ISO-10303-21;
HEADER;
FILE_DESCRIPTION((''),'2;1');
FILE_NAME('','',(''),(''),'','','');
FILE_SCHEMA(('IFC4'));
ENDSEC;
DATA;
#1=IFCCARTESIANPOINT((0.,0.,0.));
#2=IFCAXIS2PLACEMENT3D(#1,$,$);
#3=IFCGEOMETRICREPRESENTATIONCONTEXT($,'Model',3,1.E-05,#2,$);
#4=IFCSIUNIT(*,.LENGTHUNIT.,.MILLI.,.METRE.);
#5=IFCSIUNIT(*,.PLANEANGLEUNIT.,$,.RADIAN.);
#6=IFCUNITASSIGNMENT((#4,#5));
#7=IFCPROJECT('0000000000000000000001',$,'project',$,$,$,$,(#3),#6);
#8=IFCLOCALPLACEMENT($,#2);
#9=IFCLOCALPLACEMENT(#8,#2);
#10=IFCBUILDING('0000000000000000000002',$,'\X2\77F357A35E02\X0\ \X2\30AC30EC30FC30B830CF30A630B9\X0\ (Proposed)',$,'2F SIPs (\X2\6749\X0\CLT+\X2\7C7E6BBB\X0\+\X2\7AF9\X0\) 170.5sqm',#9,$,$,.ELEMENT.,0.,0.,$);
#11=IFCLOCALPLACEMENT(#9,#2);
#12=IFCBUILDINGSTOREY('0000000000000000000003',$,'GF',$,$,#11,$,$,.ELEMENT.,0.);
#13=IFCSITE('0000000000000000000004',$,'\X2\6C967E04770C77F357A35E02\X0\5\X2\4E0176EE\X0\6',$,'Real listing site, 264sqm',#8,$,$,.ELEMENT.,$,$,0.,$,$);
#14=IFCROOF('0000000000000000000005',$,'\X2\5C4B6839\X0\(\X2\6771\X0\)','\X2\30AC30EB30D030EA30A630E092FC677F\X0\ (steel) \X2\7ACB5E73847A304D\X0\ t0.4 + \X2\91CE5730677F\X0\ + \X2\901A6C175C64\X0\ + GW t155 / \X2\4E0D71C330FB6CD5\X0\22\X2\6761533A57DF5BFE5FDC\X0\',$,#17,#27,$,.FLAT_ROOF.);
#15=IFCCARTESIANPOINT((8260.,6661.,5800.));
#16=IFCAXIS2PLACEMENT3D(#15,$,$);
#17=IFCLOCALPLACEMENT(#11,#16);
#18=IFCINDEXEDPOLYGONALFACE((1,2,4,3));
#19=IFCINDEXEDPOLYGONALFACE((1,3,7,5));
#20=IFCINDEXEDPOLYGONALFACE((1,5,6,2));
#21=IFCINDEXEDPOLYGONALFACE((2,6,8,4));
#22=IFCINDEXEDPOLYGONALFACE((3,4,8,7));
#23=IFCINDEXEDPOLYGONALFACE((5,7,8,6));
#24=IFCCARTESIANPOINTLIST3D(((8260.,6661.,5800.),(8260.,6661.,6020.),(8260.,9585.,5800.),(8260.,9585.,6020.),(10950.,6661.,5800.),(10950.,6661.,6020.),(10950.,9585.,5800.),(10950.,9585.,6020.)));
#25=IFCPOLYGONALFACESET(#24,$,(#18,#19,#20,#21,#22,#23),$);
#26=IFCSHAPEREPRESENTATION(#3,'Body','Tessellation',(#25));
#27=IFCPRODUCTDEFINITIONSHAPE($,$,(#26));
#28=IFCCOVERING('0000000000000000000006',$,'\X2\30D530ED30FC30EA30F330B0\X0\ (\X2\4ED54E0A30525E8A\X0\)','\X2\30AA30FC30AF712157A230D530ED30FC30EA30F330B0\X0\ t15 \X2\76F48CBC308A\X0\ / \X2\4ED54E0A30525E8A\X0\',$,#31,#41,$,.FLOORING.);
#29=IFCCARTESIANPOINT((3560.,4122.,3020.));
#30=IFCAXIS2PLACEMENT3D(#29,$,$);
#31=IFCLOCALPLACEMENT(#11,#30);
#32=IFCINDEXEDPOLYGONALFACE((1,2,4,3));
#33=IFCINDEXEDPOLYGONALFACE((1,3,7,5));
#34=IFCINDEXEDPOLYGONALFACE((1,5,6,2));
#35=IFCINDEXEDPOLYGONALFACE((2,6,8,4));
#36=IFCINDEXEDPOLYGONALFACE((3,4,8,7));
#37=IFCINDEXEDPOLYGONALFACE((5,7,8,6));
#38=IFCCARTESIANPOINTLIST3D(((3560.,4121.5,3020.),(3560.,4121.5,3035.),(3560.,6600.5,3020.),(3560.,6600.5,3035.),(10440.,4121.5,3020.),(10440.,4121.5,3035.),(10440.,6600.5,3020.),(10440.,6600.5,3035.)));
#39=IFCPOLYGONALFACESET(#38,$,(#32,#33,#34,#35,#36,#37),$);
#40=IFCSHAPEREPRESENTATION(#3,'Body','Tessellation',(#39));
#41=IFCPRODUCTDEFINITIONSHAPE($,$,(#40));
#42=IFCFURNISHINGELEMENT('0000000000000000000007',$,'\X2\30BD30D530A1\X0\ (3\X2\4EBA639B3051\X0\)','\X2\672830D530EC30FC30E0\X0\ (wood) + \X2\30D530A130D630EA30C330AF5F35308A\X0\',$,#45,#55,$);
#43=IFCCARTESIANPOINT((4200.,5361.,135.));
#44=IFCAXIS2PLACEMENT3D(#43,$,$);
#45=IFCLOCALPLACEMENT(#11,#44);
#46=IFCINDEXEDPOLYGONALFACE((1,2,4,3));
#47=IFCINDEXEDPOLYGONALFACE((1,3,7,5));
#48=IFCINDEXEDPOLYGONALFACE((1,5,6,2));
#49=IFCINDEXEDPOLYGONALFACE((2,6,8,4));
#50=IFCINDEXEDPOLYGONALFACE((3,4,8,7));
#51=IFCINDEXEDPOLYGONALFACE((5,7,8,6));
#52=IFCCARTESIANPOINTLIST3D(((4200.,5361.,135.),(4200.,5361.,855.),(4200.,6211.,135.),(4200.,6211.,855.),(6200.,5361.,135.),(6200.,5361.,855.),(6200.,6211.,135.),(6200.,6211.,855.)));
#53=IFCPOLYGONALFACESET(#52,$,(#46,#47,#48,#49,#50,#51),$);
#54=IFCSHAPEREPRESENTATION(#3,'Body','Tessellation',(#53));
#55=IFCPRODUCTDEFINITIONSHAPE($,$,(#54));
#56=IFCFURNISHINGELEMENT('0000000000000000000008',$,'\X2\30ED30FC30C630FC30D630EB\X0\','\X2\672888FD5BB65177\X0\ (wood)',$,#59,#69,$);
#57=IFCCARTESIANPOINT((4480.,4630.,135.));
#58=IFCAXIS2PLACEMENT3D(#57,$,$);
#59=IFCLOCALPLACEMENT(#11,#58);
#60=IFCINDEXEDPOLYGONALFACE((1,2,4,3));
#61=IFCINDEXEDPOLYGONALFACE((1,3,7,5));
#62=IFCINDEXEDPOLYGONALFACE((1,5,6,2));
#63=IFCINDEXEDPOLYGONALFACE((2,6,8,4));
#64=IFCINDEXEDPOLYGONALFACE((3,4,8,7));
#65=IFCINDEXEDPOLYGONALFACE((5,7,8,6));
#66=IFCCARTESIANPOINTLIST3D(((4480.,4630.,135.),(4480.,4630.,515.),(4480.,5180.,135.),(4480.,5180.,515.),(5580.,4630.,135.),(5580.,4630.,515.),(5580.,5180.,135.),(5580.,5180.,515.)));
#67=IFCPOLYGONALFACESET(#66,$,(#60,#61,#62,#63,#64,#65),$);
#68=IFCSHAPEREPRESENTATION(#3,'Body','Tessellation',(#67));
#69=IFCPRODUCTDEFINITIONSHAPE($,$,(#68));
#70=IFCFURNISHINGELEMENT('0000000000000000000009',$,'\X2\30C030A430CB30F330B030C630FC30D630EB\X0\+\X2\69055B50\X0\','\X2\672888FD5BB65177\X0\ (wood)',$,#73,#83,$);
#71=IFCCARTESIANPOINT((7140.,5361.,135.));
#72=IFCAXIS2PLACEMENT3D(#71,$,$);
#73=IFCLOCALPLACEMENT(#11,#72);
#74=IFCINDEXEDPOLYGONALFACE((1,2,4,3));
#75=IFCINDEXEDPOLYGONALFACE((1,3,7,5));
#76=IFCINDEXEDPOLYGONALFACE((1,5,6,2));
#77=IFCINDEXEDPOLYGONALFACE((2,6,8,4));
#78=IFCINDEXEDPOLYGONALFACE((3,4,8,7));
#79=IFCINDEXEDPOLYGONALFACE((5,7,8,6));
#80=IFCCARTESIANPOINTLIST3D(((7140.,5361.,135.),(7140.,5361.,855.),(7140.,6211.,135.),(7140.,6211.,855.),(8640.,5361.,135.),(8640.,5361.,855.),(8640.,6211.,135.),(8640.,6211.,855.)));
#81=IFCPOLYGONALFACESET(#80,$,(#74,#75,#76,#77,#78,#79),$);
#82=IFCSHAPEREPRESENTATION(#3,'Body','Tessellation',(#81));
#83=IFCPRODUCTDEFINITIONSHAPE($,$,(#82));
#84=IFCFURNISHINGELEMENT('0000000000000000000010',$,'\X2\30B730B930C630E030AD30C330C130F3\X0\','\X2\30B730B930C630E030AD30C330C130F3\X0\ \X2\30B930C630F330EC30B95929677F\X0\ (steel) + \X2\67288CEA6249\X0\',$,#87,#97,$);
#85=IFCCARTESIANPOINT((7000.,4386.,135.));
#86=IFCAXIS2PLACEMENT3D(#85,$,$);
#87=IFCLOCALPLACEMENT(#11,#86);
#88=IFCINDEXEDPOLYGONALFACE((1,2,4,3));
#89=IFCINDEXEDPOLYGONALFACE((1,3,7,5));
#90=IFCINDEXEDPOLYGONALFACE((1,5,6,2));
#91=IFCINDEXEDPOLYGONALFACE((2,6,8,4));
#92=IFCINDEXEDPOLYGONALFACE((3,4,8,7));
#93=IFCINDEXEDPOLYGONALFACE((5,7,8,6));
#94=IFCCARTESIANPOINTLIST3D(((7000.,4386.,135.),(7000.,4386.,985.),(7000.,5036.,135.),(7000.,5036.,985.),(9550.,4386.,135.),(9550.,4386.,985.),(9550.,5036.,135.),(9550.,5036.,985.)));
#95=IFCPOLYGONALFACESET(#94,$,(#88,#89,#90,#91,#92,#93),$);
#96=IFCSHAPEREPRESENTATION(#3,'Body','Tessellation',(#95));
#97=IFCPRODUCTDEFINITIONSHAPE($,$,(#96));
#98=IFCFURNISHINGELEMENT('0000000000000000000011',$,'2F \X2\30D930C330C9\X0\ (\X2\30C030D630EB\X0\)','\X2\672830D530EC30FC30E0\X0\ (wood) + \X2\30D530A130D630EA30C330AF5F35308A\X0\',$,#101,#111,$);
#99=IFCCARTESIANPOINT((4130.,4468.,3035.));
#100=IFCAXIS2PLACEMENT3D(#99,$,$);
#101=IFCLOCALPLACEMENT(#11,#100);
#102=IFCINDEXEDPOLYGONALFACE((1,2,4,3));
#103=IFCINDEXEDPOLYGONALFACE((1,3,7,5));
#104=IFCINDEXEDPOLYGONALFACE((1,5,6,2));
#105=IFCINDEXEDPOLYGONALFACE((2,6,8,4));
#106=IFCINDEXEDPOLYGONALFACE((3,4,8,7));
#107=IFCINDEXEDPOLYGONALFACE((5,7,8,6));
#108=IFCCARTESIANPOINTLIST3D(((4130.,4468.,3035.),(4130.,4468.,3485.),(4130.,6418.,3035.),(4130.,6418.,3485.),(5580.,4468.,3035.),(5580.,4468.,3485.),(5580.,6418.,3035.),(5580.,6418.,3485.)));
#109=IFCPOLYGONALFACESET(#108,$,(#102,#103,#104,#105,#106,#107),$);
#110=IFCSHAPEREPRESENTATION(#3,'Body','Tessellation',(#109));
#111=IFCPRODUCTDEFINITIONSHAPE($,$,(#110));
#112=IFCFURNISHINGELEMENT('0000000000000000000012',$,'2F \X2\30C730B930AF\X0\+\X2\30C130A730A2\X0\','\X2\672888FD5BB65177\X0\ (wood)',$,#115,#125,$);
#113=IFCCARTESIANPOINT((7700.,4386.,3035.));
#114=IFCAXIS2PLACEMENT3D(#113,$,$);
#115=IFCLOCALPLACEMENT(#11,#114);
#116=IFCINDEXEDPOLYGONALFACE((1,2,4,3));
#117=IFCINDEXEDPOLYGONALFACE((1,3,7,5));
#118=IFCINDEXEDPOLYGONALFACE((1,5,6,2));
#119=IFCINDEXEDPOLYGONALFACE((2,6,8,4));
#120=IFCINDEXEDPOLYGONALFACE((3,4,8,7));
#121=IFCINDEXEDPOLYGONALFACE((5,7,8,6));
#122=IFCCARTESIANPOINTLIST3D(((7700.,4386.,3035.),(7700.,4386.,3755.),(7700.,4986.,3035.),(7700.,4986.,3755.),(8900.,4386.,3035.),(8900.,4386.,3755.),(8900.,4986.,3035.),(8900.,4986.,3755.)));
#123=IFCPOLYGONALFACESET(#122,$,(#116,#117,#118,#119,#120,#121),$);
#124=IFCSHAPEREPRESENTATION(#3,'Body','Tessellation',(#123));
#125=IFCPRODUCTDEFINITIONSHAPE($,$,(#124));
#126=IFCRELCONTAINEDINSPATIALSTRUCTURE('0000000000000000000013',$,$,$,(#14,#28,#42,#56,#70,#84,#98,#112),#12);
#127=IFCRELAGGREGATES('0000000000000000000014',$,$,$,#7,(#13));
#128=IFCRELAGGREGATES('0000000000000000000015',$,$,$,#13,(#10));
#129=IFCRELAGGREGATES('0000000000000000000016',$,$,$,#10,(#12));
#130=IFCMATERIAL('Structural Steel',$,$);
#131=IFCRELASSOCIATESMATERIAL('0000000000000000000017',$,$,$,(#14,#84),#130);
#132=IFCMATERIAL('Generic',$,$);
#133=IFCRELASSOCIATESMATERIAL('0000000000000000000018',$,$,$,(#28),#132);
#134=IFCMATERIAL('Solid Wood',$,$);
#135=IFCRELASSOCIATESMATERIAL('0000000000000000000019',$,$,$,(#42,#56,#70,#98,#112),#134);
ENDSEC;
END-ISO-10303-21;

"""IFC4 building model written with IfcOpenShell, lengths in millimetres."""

from ifc_helpers import new_model, si_unit, frame, frame_2d, origin, place, context, project, spatial, rectangle, extrude, material, element, save


model = new_model("IFC4")

# Units and contexts
model_context = context("Model", 3, precision=1e-05, world=origin())
ifc_project = project(units=[si_unit("LENGTHUNIT", "METRE", prefix="MILLI"), si_unit("PLANEANGLEUNIT", "RADIAN")], contexts=[model_context])

# Site, building, storey
site_placement = place(None, origin())
site = spatial("IfcSite", under=ifc_project, at=site_placement, Name="沖縄県石垣市5丁目6", ObjectType="Real listing site, 264sqm", CompositionType="ELEMENT", RefElevation=0.0)
building_placement = place(site_placement, origin())
building = spatial("IfcBuilding", under=site, at=building_placement, Name="石垣市 ガレージハウス (Proposed)", ObjectType="2F SIPs (杉CLT+籾殻+竹) 170.5sqm", CompositionType="ELEMENT", ElevationOfRefHeight=0.0, ElevationOfTerrain=0.0)
storey_placement = place(building_placement, origin())
storey = spatial("IfcBuildingStorey", under=building, at=storey_placement, Name="GF", CompositionType="ELEMENT", Elevation=0.0)

# Shared definitions
ifc_material_1 = material(Name="Solid Wood")

# Shared definitions
ifc_material_2 = material(Name="Generic")

# Roof
ifc_material_3 = material(Name="Structural Steel")
roof_placement = place(storey_placement, frame((8260.0, 6661.0, 5800.0)))
element("IfcRoof", 1, at=roof_placement, inside=storey, material=ifc_material_3, Name="屋根(東)", Description="ガルバリウム鋼板 (steel) 立平葺き t0.4 + 野地板 + 通気層 + GW t155 / 不燃・法22条区域対応", PredefinedType="FLAT_ROOF", context=model_context, shape_type="SweptSolid", body=[
    extrude(rectangle(XDim=2690.0, YDim=2924.0, at=frame_2d((1345.0, 1462.0))), frame((8260.0, 6661.0, 5800.0)), (0.0, 0.0, 1.0), 220.0),
])

# Covering
covering_placement = place(storey_placement, frame((3560.0, 4122.0, 3020.0)))
element("IfcCovering", 2, at=covering_placement, inside=storey, material=ifc_material_2, Name="フローリング (仕上げ床)", Description="オーク無垢フローリング t15 直貼り / 仕上げ床", PredefinedType="FLOORING", context=model_context, shape_type="SweptSolid", body=[
    extrude(rectangle(XDim=6880.0, YDim=2479.0, at=frame_2d((3440.0, 1239.0))), frame((3560.0, 4122.0, 3020.0)), (0.0, 0.0, 1.0), 15.0),
])

# Furnishing elements
furnishing_1_placement = place(storey_placement, frame((4200.0, 5361.0, 135.0)))
element("IfcFurnishingElement", 3, at=furnishing_1_placement, inside=storey, material=ifc_material_1, Name="ソファ (3人掛け)", Description="木フレーム (wood) + ファブリック張り", context=model_context, shape_type="SweptSolid", body=[
    extrude(rectangle(XDim=2000.0, YDim=850.0, at=frame_2d((1000.0, 425.0))), frame((4200.0, 5361.0, 135.0)), (0.0, 0.0, 1.0), 720.0),
])
furnishing_2_placement = place(storey_placement, frame((4480.0, 4630.0, 135.0)))
element("IfcFurnishingElement", 4, at=furnishing_2_placement, inside=storey, material=ifc_material_1, Name="ローテーブル", Description="木製家具 (wood)", context=model_context, shape_type="SweptSolid", body=[
    extrude(rectangle(XDim=1100.0, YDim=550.0, at=frame_2d((550.0, 275.0))), frame((4480.0, 4630.0, 135.0)), (0.0, 0.0, 1.0), 380.0),
])
furnishing_3_placement = place(storey_placement, frame((7140.0, 5361.0, 135.0)))
element("IfcFurnishingElement", 5, at=furnishing_3_placement, inside=storey, material=ifc_material_1, Name="ダイニングテーブル+椅子", Description="木製家具 (wood)", context=model_context, shape_type="SweptSolid", body=[
    extrude(rectangle(XDim=1500.0, YDim=850.0, at=frame_2d((750.0, 425.0))), frame((7140.0, 5361.0, 135.0)), (0.0, 0.0, 1.0), 720.0),
])
furnishing_4_placement = place(storey_placement, frame((7000.0, 4386.0, 135.0)))
element("IfcFurnishingElement", 6, at=furnishing_4_placement, inside=storey, material=ifc_material_3, Name="システムキッチン", Description="システムキッチン ステンレス天板 (steel) + 木質扉", context=model_context, shape_type="SweptSolid", body=[
    extrude(rectangle(XDim=2550.0, YDim=650.0, at=frame_2d((1275.0, 325.0))), frame((7000.0, 4386.0, 135.0)), (0.0, 0.0, 1.0), 850.0),
])
furnishing_5_placement = place(storey_placement, frame((4130.0, 4468.0, 3035.0)))
element("IfcFurnishingElement", 7, at=furnishing_5_placement, inside=storey, material=ifc_material_1, Name="2F ベッド (ダブル)", Description="木フレーム (wood) + ファブリック張り", context=model_context, shape_type="SweptSolid", body=[
    extrude(rectangle(XDim=1450.0, YDim=1950.0, at=frame_2d((725.0, 975.0))), frame((4130.0, 4468.0, 3035.0)), (0.0, 0.0, 1.0), 450.0),
])
furnishing_6_placement = place(storey_placement, frame((7700.0, 4386.0, 3035.0)))
element("IfcFurnishingElement", 8, at=furnishing_6_placement, inside=storey, material=ifc_material_1, Name="2F デスク+チェア", Description="木製家具 (wood)", context=model_context, shape_type="SweptSolid", body=[
    extrude(rectangle(XDim=1200.0, YDim=600.0, at=frame_2d((600.0, 300.0))), frame((7700.0, 4386.0, 3035.0)), (0.0, 0.0, 1.0), 720.0),
])

save(model, "model.ifc")
